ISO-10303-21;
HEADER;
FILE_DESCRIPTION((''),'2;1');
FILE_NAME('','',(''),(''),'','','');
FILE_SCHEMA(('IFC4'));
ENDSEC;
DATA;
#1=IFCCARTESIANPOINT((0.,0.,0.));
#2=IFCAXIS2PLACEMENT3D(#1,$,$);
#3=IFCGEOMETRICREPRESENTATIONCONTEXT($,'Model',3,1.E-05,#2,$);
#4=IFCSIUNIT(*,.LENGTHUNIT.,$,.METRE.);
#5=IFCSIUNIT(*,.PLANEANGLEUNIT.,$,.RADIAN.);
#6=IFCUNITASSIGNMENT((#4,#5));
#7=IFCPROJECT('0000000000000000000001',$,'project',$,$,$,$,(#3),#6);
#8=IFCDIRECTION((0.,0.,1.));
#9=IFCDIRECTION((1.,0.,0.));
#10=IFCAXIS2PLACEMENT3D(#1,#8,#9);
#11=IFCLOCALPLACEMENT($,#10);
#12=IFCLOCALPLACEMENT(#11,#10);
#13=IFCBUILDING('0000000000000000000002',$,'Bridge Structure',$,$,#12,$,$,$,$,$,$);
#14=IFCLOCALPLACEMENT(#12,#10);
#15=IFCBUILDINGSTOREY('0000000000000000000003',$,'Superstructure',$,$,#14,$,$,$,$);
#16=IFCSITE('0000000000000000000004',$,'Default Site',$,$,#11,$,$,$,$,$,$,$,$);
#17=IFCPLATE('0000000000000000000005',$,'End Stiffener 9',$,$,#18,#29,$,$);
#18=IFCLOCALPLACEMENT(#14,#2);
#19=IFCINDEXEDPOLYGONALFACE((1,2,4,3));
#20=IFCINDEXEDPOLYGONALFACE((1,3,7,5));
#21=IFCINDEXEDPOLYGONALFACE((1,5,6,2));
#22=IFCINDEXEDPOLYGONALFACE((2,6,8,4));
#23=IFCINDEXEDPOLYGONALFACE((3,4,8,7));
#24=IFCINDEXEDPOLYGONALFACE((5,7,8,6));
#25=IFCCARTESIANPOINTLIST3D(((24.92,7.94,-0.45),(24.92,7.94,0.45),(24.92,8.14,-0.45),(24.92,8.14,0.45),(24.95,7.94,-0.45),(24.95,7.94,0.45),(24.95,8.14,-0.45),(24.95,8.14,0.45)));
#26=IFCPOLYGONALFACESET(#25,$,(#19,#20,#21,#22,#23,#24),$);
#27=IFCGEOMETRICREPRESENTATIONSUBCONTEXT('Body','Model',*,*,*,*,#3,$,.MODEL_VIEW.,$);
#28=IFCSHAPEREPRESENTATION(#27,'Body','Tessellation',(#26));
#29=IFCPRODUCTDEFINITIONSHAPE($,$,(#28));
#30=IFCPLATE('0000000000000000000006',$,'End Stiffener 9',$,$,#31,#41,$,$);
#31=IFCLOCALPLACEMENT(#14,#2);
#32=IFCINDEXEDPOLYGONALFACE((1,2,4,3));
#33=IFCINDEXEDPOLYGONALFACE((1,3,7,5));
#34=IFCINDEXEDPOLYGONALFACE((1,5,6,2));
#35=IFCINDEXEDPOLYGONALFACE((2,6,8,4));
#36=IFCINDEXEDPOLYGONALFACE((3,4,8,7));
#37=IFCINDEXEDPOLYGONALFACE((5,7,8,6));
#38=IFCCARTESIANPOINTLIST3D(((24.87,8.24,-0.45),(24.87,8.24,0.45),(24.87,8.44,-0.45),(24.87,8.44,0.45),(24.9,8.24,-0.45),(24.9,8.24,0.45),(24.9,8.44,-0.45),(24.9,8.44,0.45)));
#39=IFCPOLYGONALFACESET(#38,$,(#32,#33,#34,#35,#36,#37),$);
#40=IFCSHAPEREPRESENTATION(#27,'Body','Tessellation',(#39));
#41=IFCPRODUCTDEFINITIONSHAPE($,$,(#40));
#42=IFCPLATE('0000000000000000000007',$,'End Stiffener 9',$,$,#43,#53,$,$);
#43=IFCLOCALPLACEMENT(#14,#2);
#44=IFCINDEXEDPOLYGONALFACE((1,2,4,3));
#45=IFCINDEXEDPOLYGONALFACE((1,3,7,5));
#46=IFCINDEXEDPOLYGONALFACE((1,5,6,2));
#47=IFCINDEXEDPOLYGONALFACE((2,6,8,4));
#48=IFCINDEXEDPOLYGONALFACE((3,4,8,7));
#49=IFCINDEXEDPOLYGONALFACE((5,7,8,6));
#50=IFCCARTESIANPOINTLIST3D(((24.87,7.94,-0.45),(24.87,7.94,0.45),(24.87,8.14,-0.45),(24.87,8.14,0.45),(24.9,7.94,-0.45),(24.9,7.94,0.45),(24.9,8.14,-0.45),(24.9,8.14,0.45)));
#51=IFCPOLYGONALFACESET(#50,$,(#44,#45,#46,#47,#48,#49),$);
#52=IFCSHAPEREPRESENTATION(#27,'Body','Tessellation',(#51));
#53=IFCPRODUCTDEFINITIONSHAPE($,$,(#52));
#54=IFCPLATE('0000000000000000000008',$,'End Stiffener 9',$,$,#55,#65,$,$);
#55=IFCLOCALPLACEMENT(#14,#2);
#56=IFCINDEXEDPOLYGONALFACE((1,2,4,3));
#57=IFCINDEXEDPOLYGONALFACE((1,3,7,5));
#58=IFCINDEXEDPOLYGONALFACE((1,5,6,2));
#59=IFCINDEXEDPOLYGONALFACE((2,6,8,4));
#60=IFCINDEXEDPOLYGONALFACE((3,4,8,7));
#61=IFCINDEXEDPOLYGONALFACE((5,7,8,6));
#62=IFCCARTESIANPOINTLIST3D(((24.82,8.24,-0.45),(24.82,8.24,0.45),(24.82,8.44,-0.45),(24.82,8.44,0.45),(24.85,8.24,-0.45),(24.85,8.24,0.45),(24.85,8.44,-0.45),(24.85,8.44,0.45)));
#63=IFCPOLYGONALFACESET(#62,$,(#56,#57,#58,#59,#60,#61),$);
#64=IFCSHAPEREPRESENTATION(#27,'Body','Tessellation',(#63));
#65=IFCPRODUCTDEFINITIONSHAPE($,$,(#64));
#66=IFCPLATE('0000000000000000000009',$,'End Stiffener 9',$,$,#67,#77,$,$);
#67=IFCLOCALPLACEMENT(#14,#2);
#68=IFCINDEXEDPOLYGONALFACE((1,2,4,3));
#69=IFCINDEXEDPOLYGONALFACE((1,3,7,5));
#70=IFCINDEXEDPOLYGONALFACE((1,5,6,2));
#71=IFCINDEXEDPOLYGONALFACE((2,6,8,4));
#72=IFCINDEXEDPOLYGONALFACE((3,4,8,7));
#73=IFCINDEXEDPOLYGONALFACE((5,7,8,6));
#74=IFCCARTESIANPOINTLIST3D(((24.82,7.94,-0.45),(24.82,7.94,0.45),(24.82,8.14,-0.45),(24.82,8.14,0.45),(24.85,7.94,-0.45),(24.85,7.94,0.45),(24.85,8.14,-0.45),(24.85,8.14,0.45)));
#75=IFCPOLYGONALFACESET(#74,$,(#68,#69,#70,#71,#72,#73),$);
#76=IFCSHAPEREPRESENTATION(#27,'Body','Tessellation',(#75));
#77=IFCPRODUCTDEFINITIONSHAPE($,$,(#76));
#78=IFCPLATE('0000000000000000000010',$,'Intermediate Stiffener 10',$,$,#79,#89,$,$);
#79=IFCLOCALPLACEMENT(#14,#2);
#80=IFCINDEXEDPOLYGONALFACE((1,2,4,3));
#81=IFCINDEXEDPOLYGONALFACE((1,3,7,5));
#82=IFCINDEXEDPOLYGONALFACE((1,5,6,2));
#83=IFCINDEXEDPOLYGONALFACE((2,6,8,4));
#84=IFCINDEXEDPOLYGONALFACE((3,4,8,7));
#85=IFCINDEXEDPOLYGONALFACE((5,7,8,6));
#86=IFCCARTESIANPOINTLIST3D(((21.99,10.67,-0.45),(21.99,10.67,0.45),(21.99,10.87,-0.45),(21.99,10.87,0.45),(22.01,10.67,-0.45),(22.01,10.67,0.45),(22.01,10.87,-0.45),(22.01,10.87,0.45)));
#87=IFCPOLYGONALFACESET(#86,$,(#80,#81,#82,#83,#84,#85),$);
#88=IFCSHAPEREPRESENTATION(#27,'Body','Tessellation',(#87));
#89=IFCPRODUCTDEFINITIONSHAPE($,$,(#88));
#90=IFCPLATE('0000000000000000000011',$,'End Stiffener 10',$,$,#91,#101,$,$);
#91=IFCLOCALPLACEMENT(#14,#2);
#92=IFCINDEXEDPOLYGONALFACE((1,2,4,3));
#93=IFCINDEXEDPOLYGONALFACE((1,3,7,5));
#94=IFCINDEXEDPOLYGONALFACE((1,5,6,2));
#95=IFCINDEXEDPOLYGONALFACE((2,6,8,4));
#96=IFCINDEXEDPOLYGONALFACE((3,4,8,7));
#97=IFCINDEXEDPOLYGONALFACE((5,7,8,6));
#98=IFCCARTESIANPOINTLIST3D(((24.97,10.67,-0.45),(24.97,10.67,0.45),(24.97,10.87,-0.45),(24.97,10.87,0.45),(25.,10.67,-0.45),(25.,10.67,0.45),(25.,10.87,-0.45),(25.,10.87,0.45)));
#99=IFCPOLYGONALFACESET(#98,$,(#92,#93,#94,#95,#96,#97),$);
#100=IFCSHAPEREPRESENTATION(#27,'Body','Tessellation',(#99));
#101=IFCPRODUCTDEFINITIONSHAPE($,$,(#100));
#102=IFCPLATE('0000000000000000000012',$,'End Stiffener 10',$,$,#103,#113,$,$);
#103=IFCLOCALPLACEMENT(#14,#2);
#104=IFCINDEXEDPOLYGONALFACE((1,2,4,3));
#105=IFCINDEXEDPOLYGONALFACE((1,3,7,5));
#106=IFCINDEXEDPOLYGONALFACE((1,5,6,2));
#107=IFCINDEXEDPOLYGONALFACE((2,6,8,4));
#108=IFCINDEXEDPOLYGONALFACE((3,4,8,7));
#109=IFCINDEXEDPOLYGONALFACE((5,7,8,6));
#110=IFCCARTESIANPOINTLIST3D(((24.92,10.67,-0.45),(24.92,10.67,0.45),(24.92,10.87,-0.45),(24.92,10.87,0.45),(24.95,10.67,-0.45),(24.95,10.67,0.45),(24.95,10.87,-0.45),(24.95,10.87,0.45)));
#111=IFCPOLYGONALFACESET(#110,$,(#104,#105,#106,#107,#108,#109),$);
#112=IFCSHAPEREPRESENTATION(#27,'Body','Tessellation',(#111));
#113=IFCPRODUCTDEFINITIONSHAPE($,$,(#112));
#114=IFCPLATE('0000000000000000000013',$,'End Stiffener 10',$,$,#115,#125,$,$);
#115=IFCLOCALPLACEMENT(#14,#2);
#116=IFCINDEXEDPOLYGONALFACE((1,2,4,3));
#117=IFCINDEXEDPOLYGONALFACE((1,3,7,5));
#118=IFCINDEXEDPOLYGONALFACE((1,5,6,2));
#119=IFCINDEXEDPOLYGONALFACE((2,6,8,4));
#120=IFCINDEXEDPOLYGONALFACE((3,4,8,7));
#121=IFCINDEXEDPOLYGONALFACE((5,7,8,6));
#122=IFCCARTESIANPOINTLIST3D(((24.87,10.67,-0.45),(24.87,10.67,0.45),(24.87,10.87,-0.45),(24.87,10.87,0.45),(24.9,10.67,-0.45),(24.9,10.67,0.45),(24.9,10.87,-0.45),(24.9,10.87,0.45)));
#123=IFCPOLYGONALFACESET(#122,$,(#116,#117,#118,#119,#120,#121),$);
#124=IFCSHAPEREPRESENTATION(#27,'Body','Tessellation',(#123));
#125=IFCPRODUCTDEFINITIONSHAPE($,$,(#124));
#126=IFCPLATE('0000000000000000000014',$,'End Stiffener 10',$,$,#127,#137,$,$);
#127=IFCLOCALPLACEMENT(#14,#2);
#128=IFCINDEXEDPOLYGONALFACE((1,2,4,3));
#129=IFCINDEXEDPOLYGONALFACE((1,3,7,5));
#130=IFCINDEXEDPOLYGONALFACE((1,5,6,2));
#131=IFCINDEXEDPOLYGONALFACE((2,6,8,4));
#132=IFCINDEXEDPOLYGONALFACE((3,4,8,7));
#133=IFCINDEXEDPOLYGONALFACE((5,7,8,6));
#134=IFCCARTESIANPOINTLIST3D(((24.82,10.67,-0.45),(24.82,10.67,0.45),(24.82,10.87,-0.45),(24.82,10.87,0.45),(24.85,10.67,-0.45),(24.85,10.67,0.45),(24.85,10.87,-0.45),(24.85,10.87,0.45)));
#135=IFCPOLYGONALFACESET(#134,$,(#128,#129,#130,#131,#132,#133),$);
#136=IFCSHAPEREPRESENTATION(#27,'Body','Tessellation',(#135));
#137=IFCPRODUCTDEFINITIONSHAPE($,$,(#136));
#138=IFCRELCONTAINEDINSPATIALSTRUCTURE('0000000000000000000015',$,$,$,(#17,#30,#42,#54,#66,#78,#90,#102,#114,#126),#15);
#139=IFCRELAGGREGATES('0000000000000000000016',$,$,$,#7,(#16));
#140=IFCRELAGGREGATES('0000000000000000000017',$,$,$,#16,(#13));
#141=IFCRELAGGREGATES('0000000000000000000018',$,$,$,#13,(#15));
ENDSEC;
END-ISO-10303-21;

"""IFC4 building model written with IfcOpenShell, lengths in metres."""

from ifc_helpers import new_model, si_unit, frame, origin, origin_with_axes, origin_2d_with_axis, place, context, subcontext, project, spatial, rectangle, extrude, element, save


model = new_model("IFC4")

# Units and contexts
model_context = context("Model", 3, precision=1e-05, world=origin())
body_context = subcontext(model_context, "Body", "Model", "MODEL_VIEW")
ifc_project = project(units=[si_unit("LENGTHUNIT", "METRE"), si_unit("PLANEANGLEUNIT", "RADIAN")], contexts=[model_context])

# Site, building, storey
site_placement = place(None, origin_with_axes())
site = spatial("IfcSite", under=ifc_project, at=site_placement, Name="Default Site")
building_placement = place(site_placement, origin_with_axes())
building = spatial("IfcBuilding", under=site, at=building_placement, Name="Bridge Structure")
storey_placement = place(building_placement, origin_with_axes())
storey = spatial("IfcBuildingStorey", under=building, at=storey_placement, Name="Superstructure")

# Plates
for number, where, z_axis, x_axis, name in (
    (1, (24.935, 8.04, -0.45), (0.0, 0.0, 1.0), (1.0, 0.0, 0.0), "End Stiffener 9"),
    (2, (24.885, 8.34, -0.45), (0.0, 0.0, 1.0), (1.0, 0.0, 0.0), "End Stiffener 9"),
    (3, (24.885, 8.04, -0.45), (0.0, 0.0, 1.0), (1.0, 0.0, 0.0), "End Stiffener 9"),
    (4, (24.835, 8.34, -0.45), (0.0, 0.0, 1.0), (1.0, 0.0, 0.0), "End Stiffener 9"),
    (5, (24.835, 8.04, -0.45), (0.0, 0.0, 1.0), (1.0, 0.0, 0.0), "End Stiffener 9"),
):
    element("IfcPlate", number, at=place(storey_placement, frame(where, z_axis=z_axis, x_axis=x_axis)), inside=storey, Name=name, context=body_context, shape_type="SweptSolid", body=[
        extrude(rectangle(XDim=0.03, YDim=0.2, at=origin_2d_with_axis()), origin_with_axes(), (0.0, 0.0, 1.0), 0.9),
    ])
plate_placement = place(storey_placement, frame((22.0, 10.77, -0.45), z_axis=(0.0, 0.0, 1.0), x_axis=(1.0, 0.0, 0.0)))
element("IfcPlate", 6, at=plate_placement, inside=storey, Name="Intermediate Stiffener 10", context=body_context, shape_type="SweptSolid", body=[
    extrude(rectangle(XDim=0.02, YDim=0.2, at=origin_2d_with_axis()), origin_with_axes(), (0.0, 0.0, 1.0), 0.9),
])
for number, where, z_axis, x_axis, name in (
    (7, (24.985, 10.77, -0.45), (0.0, 0.0, 1.0), (1.0, 0.0, 0.0), "End Stiffener 10"),
    (8, (24.935, 10.77, -0.45), (0.0, 0.0, 1.0), (1.0, 0.0, 0.0), "End Stiffener 10"),
    (9, (24.885, 10.77, -0.45), (0.0, 0.0, 1.0), (1.0, 0.0, 0.0), "End Stiffener 10"),
    (10, (24.835, 10.77, -0.45), (0.0, 0.0, 1.0), (1.0, 0.0, 0.0), "End Stiffener 10"),
):
    element("IfcPlate", number, at=place(storey_placement, frame(where, z_axis=z_axis, x_axis=x_axis)), inside=storey, Name=name, context=body_context, shape_type="SweptSolid", body=[
        extrude(rectangle(XDim=0.03, YDim=0.2, at=origin_2d_with_axis()), origin_with_axes(), (0.0, 0.0, 1.0), 0.9),
    ])

save(model, "model.ifc")
